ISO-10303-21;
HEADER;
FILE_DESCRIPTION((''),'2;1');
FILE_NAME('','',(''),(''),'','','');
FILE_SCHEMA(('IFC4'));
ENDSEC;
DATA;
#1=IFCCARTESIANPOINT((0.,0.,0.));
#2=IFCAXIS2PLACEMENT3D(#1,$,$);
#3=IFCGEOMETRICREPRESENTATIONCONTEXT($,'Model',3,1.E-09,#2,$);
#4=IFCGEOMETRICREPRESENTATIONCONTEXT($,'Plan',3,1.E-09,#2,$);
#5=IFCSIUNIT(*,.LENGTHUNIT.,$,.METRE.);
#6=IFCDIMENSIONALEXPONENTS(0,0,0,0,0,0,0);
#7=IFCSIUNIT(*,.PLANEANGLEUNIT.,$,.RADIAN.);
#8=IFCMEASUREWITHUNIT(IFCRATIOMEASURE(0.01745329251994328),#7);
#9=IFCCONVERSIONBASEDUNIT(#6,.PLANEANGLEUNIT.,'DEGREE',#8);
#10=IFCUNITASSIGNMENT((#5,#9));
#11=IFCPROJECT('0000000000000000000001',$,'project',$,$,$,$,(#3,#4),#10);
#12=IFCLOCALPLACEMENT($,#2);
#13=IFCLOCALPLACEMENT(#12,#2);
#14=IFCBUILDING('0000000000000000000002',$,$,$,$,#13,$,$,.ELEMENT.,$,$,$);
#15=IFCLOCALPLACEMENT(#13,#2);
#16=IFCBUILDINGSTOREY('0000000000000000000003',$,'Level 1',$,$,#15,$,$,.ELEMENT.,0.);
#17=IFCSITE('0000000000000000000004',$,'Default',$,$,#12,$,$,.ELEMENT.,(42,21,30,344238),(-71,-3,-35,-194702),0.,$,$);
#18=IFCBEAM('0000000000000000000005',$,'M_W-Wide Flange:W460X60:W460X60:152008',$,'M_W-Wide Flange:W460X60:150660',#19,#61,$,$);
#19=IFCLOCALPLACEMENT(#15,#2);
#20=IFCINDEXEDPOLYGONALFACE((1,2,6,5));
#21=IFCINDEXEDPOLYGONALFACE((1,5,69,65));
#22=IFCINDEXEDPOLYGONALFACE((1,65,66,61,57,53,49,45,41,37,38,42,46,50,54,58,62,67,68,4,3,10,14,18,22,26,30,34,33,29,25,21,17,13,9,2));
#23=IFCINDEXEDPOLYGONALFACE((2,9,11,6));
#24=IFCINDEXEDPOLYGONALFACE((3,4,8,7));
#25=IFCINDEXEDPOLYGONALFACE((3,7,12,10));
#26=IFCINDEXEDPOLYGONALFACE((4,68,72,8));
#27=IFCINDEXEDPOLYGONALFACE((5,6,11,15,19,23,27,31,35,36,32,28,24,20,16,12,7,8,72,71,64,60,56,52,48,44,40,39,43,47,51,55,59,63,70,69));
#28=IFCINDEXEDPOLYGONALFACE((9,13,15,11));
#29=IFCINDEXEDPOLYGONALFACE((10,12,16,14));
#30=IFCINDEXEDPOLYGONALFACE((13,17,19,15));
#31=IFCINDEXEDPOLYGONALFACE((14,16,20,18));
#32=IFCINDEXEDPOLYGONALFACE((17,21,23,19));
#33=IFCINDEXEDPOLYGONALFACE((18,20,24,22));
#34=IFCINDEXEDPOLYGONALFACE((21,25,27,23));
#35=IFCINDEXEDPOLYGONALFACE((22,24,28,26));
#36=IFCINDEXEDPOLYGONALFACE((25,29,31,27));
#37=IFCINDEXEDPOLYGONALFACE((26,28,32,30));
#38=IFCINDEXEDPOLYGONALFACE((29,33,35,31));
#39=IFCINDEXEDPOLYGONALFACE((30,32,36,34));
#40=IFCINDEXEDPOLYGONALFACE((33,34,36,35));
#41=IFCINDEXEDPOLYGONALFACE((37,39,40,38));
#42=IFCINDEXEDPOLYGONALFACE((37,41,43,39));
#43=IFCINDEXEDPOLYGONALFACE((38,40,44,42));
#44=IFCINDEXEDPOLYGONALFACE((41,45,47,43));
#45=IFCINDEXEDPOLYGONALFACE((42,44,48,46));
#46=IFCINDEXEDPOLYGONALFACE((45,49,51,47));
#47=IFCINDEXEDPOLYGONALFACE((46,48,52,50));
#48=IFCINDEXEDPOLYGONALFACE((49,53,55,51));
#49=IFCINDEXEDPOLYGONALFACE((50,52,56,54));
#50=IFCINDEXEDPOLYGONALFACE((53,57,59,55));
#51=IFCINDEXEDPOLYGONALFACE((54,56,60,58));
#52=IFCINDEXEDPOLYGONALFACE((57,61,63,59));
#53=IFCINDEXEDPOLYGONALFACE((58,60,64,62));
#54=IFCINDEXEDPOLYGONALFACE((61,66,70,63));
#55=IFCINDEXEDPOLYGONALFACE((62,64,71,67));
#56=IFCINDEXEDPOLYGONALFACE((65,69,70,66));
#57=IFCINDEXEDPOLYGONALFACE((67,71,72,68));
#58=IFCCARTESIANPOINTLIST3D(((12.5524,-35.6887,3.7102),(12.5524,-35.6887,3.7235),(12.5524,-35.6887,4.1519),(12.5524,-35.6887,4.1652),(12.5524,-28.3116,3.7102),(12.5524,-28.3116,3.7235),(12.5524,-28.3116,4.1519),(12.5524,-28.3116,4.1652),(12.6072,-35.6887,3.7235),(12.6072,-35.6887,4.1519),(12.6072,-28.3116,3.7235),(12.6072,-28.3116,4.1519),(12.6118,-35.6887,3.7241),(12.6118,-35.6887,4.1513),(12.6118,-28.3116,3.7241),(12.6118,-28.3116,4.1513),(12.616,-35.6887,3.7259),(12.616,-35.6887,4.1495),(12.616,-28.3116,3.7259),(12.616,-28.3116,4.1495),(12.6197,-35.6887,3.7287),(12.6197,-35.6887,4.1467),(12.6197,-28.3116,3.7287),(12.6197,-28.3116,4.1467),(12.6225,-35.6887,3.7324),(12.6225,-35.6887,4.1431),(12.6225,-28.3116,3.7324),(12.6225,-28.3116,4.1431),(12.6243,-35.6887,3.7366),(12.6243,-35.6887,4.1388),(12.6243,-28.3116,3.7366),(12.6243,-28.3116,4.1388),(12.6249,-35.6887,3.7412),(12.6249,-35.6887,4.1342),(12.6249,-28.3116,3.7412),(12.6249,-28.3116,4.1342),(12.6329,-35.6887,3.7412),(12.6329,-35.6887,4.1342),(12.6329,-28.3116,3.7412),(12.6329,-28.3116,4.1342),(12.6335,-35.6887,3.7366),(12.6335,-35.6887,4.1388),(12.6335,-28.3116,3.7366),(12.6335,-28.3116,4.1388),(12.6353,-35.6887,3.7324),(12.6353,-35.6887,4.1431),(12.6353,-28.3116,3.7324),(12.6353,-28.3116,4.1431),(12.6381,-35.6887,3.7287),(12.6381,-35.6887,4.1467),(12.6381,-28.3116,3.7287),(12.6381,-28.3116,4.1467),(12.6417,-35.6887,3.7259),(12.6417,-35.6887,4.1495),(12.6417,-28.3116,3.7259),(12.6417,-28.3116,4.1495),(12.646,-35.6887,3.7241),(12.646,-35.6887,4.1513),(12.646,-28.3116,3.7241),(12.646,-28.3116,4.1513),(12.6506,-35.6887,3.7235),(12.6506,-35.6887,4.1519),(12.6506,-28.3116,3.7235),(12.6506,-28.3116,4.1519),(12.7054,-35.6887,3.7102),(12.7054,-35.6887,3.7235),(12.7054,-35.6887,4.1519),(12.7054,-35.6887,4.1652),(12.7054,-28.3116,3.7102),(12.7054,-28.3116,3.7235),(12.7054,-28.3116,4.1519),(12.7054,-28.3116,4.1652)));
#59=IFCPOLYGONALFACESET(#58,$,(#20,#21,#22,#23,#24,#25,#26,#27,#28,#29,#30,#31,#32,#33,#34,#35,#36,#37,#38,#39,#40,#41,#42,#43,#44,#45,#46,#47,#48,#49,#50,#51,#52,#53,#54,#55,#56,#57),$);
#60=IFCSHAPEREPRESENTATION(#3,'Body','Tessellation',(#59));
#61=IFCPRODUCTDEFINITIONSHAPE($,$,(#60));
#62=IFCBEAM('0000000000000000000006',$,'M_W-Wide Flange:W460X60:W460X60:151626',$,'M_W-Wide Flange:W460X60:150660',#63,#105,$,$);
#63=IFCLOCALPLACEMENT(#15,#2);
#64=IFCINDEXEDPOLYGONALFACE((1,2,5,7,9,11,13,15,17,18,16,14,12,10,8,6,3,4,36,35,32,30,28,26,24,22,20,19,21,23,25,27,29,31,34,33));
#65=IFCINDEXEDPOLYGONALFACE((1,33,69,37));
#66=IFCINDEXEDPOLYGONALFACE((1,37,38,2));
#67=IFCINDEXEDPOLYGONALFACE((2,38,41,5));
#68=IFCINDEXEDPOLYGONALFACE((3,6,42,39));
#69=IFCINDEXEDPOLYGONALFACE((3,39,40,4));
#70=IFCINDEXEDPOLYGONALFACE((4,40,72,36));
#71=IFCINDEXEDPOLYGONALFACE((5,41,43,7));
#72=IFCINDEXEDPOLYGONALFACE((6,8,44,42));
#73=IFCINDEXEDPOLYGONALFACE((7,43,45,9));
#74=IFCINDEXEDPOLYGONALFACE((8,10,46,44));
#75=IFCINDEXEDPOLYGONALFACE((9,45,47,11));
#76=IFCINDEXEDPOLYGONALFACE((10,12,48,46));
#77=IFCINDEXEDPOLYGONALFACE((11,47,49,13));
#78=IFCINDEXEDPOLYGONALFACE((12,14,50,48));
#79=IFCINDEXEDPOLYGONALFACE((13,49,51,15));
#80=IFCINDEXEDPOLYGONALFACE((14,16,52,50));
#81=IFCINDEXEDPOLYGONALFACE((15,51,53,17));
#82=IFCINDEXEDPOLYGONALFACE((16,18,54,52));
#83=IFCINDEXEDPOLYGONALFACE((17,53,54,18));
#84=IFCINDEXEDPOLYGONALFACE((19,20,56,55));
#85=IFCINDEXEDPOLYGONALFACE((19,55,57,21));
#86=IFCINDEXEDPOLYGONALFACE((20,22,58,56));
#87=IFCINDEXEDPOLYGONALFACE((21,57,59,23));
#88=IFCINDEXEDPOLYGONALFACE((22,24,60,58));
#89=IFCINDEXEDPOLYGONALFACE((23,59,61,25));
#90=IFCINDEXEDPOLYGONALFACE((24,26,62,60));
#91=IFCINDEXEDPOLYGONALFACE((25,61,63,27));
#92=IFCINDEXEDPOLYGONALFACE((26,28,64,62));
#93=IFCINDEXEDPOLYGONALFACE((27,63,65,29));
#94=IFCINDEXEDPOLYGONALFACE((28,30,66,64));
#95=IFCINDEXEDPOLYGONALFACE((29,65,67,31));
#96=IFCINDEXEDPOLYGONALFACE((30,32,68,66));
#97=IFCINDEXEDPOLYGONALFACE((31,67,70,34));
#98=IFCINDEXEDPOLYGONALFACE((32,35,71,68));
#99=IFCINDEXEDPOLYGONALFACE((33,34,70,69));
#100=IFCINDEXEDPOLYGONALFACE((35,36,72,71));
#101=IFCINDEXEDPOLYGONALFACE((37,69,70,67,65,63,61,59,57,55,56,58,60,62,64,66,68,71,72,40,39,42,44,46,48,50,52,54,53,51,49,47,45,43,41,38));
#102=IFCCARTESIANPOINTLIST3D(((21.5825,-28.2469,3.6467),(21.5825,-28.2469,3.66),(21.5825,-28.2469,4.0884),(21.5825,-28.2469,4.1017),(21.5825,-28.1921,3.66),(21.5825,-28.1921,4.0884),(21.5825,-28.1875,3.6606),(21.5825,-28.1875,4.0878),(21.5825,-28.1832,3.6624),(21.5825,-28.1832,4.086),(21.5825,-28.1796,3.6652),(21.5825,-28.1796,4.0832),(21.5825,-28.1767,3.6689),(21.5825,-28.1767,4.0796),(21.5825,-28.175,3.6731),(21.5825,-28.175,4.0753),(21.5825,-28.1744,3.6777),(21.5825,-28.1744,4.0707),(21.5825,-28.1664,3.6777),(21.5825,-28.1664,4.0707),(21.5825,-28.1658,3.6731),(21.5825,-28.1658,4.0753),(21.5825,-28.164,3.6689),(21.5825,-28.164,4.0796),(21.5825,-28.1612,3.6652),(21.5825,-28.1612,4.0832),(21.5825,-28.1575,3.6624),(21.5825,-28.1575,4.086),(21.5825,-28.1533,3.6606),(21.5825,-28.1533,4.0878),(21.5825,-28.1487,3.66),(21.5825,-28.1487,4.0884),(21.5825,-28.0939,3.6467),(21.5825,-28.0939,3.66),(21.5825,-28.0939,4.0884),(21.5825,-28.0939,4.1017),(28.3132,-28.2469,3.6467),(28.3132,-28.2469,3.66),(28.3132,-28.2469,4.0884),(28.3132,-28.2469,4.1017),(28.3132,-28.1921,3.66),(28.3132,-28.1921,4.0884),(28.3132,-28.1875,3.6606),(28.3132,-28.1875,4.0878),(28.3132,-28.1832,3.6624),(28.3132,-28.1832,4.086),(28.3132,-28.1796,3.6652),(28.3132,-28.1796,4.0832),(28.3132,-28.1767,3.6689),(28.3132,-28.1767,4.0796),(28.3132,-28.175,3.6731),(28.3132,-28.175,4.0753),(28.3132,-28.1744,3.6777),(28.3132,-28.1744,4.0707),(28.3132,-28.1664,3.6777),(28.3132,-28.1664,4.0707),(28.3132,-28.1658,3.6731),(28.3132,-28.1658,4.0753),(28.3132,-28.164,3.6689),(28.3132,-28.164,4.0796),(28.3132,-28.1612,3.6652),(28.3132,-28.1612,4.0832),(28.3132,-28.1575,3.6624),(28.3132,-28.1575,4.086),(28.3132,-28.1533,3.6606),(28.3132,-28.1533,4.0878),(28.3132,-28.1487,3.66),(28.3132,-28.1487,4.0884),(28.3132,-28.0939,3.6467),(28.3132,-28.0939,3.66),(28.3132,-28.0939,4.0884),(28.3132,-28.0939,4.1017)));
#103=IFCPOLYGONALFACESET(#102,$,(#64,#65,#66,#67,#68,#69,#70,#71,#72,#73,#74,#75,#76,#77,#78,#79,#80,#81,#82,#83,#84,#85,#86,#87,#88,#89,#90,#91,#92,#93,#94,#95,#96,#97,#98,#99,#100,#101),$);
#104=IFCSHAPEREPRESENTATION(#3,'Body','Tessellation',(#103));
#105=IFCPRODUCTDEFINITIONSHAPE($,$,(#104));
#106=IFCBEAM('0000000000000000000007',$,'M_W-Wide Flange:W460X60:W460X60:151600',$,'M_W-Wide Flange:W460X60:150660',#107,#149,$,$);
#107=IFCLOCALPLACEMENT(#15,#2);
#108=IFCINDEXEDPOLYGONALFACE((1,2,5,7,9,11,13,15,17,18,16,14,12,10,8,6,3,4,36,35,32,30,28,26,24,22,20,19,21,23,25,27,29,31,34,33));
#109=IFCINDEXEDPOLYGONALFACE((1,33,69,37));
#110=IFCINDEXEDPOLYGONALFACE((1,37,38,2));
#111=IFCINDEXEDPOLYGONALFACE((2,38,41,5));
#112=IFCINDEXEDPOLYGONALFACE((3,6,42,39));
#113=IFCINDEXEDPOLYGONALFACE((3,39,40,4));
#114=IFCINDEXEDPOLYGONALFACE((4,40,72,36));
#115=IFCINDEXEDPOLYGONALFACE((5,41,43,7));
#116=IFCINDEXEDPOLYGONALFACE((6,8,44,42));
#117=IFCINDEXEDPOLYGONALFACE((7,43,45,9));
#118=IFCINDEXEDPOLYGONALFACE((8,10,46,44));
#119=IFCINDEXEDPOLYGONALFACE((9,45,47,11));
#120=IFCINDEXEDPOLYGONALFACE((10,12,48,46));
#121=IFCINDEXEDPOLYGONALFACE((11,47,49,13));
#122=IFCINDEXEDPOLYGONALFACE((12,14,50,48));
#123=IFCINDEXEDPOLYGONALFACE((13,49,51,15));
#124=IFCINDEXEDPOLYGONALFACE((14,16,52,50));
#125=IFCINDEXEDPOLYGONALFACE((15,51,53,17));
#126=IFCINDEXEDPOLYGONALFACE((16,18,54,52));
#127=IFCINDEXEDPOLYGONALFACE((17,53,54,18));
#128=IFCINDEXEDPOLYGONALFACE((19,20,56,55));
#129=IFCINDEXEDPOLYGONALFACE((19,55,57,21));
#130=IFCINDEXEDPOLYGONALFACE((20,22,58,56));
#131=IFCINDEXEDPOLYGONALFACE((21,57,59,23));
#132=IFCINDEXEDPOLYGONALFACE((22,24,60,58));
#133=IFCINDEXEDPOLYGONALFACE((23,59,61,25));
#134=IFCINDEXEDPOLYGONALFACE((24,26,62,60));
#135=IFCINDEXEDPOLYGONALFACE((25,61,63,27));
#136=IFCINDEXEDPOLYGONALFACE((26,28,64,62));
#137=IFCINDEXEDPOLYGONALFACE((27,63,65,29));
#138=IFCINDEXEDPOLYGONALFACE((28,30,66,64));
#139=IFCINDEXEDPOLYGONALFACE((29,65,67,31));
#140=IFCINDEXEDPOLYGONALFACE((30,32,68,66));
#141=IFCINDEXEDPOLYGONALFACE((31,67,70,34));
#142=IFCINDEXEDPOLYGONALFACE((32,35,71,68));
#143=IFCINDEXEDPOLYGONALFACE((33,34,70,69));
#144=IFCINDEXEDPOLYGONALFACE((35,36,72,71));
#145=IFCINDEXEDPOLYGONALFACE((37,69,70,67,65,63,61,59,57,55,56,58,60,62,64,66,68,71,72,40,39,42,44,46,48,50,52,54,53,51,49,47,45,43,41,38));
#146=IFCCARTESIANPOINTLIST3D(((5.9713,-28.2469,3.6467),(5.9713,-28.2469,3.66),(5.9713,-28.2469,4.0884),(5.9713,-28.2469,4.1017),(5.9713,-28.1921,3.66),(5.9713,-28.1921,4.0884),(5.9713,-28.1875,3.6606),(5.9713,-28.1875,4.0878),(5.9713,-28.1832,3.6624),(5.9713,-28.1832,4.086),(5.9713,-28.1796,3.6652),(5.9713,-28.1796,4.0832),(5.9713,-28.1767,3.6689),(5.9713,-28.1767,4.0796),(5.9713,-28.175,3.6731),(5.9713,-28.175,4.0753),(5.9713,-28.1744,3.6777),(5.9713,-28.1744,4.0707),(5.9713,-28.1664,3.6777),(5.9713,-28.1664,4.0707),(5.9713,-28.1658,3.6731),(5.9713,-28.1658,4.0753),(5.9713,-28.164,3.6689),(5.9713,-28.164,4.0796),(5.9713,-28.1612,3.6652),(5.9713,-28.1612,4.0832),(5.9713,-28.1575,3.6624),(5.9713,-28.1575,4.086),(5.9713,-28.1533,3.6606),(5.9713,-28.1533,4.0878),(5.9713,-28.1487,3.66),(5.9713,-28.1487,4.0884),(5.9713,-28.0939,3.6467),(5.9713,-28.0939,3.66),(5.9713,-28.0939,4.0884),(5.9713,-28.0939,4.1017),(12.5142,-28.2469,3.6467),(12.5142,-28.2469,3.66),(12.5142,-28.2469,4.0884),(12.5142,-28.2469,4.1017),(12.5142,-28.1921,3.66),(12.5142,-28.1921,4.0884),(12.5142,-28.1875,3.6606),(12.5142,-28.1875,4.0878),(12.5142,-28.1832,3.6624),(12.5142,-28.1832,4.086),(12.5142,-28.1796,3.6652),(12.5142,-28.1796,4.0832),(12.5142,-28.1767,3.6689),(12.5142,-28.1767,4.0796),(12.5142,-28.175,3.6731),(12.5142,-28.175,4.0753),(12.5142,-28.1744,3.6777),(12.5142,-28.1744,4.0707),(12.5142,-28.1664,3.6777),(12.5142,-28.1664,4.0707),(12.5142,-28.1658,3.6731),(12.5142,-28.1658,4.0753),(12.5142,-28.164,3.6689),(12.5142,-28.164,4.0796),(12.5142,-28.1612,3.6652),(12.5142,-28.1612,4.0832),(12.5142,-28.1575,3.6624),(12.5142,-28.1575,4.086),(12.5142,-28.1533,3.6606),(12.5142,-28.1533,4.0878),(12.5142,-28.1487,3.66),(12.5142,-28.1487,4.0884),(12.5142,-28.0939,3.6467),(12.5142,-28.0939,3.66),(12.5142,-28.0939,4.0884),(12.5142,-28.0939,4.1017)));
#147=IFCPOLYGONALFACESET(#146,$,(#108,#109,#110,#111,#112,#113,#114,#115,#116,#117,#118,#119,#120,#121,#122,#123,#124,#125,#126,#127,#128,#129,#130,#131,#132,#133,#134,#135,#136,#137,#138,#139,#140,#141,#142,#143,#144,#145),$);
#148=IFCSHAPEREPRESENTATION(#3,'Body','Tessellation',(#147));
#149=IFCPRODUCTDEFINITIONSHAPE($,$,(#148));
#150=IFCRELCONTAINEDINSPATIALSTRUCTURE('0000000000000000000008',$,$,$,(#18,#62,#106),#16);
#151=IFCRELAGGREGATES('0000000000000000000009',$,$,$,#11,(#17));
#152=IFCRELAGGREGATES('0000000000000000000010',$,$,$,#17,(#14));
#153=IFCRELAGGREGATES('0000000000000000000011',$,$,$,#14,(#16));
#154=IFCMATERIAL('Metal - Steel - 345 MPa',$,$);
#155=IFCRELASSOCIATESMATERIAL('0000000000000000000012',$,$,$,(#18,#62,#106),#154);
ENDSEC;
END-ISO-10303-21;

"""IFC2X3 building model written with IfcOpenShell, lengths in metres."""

from ifc_helpers import new_model, entity, si_unit, converted_unit, frame, frame_2d, origin, place, context, project, spatial, polyline, circle_curve, parameter, trimmed, segment, composite_curve, outline, extrude, material, element, save


model = new_model("IFC2X3")

# Units and contexts
model_context = context("Model", 3, precision=1e-09, world=origin())
plan_context = context("Plan", 3, precision=1e-09, world=origin())
ifc_project = project(units=[si_unit("LENGTHUNIT", "METRE"), converted_unit("PLANEANGLEUNIT", "DEGREE", entity("IfcRatioMeasure", 0.01745329251994328), si_unit("PLANEANGLEUNIT", "RADIAN"), dimensions=[0, 0, 0, 0, 0, 0, 0])], contexts=[model_context, plan_context])

# Site, building, storey
site_placement = place(None, origin())
site = spatial("IfcSite", under=ifc_project, at=site_placement, Name="Default", CompositionType="ELEMENT", RefLatitude=(42, 21, 30, 344238), RefLongitude=(-71, -3, -35, -194702), RefElevation=0.0)
building_placement = place(site_placement, origin())
building = spatial("IfcBuilding", under=site, at=building_placement, CompositionType="ELEMENT")
storey_placement = place(building_placement, origin())
storey = spatial("IfcBuildingStorey", under=building, at=storey_placement, Name="Level 1", CompositionType="ELEMENT", Elevation=0.0)

# Beams
ifc_material_1 = material(Name="Metal - Steel - 345 MPa")
beam_1_placement = place(storey_placement, frame((12.6289, -28.1704, 4.2672), z_axis=(0.0, 0.0, 1.0), x_axis=(-1.0, 0.0, 0.0)))
element("IfcBeam", 1, at=beam_1_placement, inside=storey, material=ifc_material_1, Name="M_W-Wide Flange:W460X60:W460X60:152008", ObjectType="M_W-Wide Flange:W460X60:150660", context=model_context, shape_type="SweptSolid", body=[
    extrude(outline(composite_curve([segment(polyline([(0.2142, -0.0765), (0.2275, -0.0765)]), True, "CONTINUOUS"), segment(polyline([(0.2275, -0.0765), (0.2275, 0.0765)]), True, "CONTINUOUS"), segment(polyline([(0.2275, 0.0765), (0.2142, 0.0765)]), True, "CONTINUOUS"), segment(polyline([(0.2142, 0.0765), (0.2142, 0.0217)]), True, "CONTINUOUS"), segment(trimmed(circle_curve(frame_2d((0.1965, 0.0217), x_axis=(1.0, 0.0)), 0.0177), [parameter(270.0)], [parameter(360.0)], True, "PARAMETER"), False, "CONTINUOUS"), segment(polyline([(0.1965, 0.004), (-0.1965, 0.004)]), True, "CONTINUOUS"), segment(trimmed(circle_curve(frame_2d((-0.1965, 0.0217), x_axis=(0.0, -1.0)), 0.0177), [parameter(270.0)], [parameter(360.0)], True, "PARAMETER"), False, "CONTINUOUS"), segment(polyline([(-0.2142, 0.0217), (-0.2142, 0.0765)]), True, "CONTINUOUS"), segment(polyline([(-0.2142, 0.0765), (-0.2275, 0.0765)]), True, "CONTINUOUS"), segment(polyline([(-0.2275, 0.0765), (-0.2275, -0.0765)]), True, "CONTINUOUS"), segment(polyline([(-0.2275, -0.0765), (-0.2142, -0.0765)]), True, "CONTINUOUS"), segment(polyline([(-0.2142, -0.0765), (-0.2142, -0.0217)]), True, "CONTINUOUS"), segment(trimmed(circle_curve(frame_2d((-0.1965, -0.0217), x_axis=(-1.0, 0.0)), 0.0177), [parameter(270.0)], [parameter(360.0)], True, "PARAMETER"), False, "CONTINUOUS"), segment(polyline([(-0.1965, -0.004), (0.1965, -0.004)]), True, "CONTINUOUS"), segment(trimmed(circle_curve(frame_2d((0.1965, -0.0217), x_axis=(0.0, 1.0)), 0.0177), [parameter(270.0)], [parameter(0.0)], True, "PARAMETER"), False, "CONTINUOUS"), segment(polyline([(0.2142, -0.0217), (0.2142, -0.0765)]), True, "CONTINUOUS")], self_intersect=False)), frame((0.0, 7.5183, -0.3295), z_axis=(0.0, -1.0, 0.0), x_axis=(0.0, 0.0, -1.0)), (0.0, 0.0, 1.0), 7.3771),
])
beam_2_placement = place(storey_placement, frame((21.4678, -28.1704, 4.2672), z_axis=(0.0, 0.0, 1.0), x_axis=(0.0, -1.0, 0.0)))
element("IfcBeam", 2, at=beam_2_placement, inside=storey, material=ifc_material_1, Name="M_W-Wide Flange:W460X60:W460X60:151626", ObjectType="M_W-Wide Flange:W460X60:150660", context=model_context, shape_type="SweptSolid", body=[
    extrude(outline(composite_curve([segment(polyline([(-0.0765, -0.2142), (-0.0765, -0.2275)]), True, "CONTINUOUS"), segment(polyline([(-0.0765, -0.2275), (0.0765, -0.2275)]), True, "CONTINUOUS"), segment(polyline([(0.0765, -0.2275), (0.0765, -0.2142)]), True, "CONTINUOUS"), segment(polyline([(0.0765, -0.2142), (0.0217, -0.2142)]), True, "CONTINUOUS"), segment(trimmed(circle_curve(frame_2d((0.0217, -0.1965), x_axis=(0.0, -1.0)), 0.0177), [parameter(270.0)], [parameter(360.0)], True, "PARAMETER"), False, "CONTINUOUS"), segment(polyline([(0.004, -0.1965), (0.004, 0.1965)]), True, "CONTINUOUS"), segment(trimmed(circle_curve(frame_2d((0.0217, 0.1965), x_axis=(-1.0, 0.0)), 0.0177), [parameter(270.0)], [parameter(360.0)], True, "PARAMETER"), False, "CONTINUOUS"), segment(polyline([(0.0217, 0.2142), (0.0765, 0.2142)]), True, "CONTINUOUS"), segment(polyline([(0.0765, 0.2142), (0.0765, 0.2275)]), True, "CONTINUOUS"), segment(polyline([(0.0765, 0.2275), (-0.0765, 0.2275)]), True, "CONTINUOUS"), segment(polyline([(-0.0765, 0.2275), (-0.0765, 0.2142)]), True, "CONTINUOUS"), segment(polyline([(-0.0765, 0.2142), (-0.0217, 0.2142)]), True, "CONTINUOUS"), segment(trimmed(circle_curve(frame_2d((-0.0217, 0.1965), x_axis=(0.0, 1.0)), 0.0177), [parameter(270.0)], [parameter(360.0)], True, "PARAMETER"), False, "CONTINUOUS"), segment(polyline([(-0.004, 0.1965), (-0.004, -0.1965)]), True, "CONTINUOUS"), segment(trimmed(circle_curve(frame_2d((-0.0217, -0.1965), x_axis=(1.0, 0.0)), 0.0177), [parameter(270.0)], [parameter(0.0)], True, "PARAMETER"), False, "CONTINUOUS"), segment(polyline([(-0.0217, -0.2142), (-0.0765, -0.2142)]), True, "CONTINUOUS")], self_intersect=False)), frame((0.0, 0.1147, -0.393), z_axis=(0.0, -1.0, 0.0), x_axis=(1.0, 0.0, 0.0)), (0.0, 0.0, -1.0), 6.7307),
])
beam_3_placement = place(storey_placement, frame((5.8566, -28.1704, 4.2672), z_axis=(0.0, 0.0, 1.0), x_axis=(0.0, -1.0, 0.0)))
element("IfcBeam", 3, at=beam_3_placement, inside=storey, material=ifc_material_1, Name="M_W-Wide Flange:W460X60:W460X60:151600", ObjectType="M_W-Wide Flange:W460X60:150660", context=model_context, shape_type="SweptSolid", body=[
    extrude(outline(composite_curve([segment(polyline([(-0.0765, -0.2142), (-0.0765, -0.2275)]), True, "CONTINUOUS"), segment(polyline([(-0.0765, -0.2275), (0.0765, -0.2275)]), True, "CONTINUOUS"), segment(polyline([(0.0765, -0.2275), (0.0765, -0.2142)]), True, "CONTINUOUS"), segment(polyline([(0.0765, -0.2142), (0.0217, -0.2142)]), True, "CONTINUOUS"), segment(trimmed(circle_curve(frame_2d((0.0217, -0.1965), x_axis=(0.0, -1.0)), 0.0177), [parameter(270.0)], [parameter(360.0)], True, "PARAMETER"), False, "CONTINUOUS"), segment(polyline([(0.004, -0.1965), (0.004, 0.1965)]), True, "CONTINUOUS"), segment(trimmed(circle_curve(frame_2d((0.0217, 0.1965), x_axis=(-1.0, 0.0)), 0.0177), [parameter(270.0)], [parameter(360.0)], True, "PARAMETER"), False, "CONTINUOUS"), segment(polyline([(0.0217, 0.2142), (0.0765, 0.2142)]), True, "CONTINUOUS"), segment(polyline([(0.0765, 0.2142), (0.0765, 0.2275)]), True, "CONTINUOUS"), segment(polyline([(0.0765, 0.2275), (-0.0765, 0.2275)]), True, "CONTINUOUS"), segment(polyline([(-0.0765, 0.2275), (-0.0765, 0.2142)]), True, "CONTINUOUS"), segment(polyline([(-0.0765, 0.2142), (-0.0217, 0.2142)]), True, "CONTINUOUS"), segment(trimmed(circle_curve(frame_2d((-0.0217, 0.1965), x_axis=(0.0, 1.0)), 0.0177), [parameter(270.0)], [parameter(360.0)], True, "PARAMETER"), False, "CONTINUOUS"), segment(polyline([(-0.004, 0.1965), (-0.004, -0.1965)]), True, "CONTINUOUS"), segment(trimmed(circle_curve(frame_2d((-0.0217, -0.1965), x_axis=(1.0, 0.0)), 0.0177), [parameter(270.0)], [parameter(0.0)], True, "PARAMETER"), False, "CONTINUOUS"), segment(polyline([(-0.0217, -0.2142), (-0.0765, -0.2142)]), True, "CONTINUOUS")], self_intersect=False)), frame((0.0, 0.1147, -0.393), z_axis=(0.0, -1.0, 0.0), x_axis=(1.0, 0.0, 0.0)), (0.0, 0.0, -1.0), 6.5429),
])

save(model, "model.ifc")
